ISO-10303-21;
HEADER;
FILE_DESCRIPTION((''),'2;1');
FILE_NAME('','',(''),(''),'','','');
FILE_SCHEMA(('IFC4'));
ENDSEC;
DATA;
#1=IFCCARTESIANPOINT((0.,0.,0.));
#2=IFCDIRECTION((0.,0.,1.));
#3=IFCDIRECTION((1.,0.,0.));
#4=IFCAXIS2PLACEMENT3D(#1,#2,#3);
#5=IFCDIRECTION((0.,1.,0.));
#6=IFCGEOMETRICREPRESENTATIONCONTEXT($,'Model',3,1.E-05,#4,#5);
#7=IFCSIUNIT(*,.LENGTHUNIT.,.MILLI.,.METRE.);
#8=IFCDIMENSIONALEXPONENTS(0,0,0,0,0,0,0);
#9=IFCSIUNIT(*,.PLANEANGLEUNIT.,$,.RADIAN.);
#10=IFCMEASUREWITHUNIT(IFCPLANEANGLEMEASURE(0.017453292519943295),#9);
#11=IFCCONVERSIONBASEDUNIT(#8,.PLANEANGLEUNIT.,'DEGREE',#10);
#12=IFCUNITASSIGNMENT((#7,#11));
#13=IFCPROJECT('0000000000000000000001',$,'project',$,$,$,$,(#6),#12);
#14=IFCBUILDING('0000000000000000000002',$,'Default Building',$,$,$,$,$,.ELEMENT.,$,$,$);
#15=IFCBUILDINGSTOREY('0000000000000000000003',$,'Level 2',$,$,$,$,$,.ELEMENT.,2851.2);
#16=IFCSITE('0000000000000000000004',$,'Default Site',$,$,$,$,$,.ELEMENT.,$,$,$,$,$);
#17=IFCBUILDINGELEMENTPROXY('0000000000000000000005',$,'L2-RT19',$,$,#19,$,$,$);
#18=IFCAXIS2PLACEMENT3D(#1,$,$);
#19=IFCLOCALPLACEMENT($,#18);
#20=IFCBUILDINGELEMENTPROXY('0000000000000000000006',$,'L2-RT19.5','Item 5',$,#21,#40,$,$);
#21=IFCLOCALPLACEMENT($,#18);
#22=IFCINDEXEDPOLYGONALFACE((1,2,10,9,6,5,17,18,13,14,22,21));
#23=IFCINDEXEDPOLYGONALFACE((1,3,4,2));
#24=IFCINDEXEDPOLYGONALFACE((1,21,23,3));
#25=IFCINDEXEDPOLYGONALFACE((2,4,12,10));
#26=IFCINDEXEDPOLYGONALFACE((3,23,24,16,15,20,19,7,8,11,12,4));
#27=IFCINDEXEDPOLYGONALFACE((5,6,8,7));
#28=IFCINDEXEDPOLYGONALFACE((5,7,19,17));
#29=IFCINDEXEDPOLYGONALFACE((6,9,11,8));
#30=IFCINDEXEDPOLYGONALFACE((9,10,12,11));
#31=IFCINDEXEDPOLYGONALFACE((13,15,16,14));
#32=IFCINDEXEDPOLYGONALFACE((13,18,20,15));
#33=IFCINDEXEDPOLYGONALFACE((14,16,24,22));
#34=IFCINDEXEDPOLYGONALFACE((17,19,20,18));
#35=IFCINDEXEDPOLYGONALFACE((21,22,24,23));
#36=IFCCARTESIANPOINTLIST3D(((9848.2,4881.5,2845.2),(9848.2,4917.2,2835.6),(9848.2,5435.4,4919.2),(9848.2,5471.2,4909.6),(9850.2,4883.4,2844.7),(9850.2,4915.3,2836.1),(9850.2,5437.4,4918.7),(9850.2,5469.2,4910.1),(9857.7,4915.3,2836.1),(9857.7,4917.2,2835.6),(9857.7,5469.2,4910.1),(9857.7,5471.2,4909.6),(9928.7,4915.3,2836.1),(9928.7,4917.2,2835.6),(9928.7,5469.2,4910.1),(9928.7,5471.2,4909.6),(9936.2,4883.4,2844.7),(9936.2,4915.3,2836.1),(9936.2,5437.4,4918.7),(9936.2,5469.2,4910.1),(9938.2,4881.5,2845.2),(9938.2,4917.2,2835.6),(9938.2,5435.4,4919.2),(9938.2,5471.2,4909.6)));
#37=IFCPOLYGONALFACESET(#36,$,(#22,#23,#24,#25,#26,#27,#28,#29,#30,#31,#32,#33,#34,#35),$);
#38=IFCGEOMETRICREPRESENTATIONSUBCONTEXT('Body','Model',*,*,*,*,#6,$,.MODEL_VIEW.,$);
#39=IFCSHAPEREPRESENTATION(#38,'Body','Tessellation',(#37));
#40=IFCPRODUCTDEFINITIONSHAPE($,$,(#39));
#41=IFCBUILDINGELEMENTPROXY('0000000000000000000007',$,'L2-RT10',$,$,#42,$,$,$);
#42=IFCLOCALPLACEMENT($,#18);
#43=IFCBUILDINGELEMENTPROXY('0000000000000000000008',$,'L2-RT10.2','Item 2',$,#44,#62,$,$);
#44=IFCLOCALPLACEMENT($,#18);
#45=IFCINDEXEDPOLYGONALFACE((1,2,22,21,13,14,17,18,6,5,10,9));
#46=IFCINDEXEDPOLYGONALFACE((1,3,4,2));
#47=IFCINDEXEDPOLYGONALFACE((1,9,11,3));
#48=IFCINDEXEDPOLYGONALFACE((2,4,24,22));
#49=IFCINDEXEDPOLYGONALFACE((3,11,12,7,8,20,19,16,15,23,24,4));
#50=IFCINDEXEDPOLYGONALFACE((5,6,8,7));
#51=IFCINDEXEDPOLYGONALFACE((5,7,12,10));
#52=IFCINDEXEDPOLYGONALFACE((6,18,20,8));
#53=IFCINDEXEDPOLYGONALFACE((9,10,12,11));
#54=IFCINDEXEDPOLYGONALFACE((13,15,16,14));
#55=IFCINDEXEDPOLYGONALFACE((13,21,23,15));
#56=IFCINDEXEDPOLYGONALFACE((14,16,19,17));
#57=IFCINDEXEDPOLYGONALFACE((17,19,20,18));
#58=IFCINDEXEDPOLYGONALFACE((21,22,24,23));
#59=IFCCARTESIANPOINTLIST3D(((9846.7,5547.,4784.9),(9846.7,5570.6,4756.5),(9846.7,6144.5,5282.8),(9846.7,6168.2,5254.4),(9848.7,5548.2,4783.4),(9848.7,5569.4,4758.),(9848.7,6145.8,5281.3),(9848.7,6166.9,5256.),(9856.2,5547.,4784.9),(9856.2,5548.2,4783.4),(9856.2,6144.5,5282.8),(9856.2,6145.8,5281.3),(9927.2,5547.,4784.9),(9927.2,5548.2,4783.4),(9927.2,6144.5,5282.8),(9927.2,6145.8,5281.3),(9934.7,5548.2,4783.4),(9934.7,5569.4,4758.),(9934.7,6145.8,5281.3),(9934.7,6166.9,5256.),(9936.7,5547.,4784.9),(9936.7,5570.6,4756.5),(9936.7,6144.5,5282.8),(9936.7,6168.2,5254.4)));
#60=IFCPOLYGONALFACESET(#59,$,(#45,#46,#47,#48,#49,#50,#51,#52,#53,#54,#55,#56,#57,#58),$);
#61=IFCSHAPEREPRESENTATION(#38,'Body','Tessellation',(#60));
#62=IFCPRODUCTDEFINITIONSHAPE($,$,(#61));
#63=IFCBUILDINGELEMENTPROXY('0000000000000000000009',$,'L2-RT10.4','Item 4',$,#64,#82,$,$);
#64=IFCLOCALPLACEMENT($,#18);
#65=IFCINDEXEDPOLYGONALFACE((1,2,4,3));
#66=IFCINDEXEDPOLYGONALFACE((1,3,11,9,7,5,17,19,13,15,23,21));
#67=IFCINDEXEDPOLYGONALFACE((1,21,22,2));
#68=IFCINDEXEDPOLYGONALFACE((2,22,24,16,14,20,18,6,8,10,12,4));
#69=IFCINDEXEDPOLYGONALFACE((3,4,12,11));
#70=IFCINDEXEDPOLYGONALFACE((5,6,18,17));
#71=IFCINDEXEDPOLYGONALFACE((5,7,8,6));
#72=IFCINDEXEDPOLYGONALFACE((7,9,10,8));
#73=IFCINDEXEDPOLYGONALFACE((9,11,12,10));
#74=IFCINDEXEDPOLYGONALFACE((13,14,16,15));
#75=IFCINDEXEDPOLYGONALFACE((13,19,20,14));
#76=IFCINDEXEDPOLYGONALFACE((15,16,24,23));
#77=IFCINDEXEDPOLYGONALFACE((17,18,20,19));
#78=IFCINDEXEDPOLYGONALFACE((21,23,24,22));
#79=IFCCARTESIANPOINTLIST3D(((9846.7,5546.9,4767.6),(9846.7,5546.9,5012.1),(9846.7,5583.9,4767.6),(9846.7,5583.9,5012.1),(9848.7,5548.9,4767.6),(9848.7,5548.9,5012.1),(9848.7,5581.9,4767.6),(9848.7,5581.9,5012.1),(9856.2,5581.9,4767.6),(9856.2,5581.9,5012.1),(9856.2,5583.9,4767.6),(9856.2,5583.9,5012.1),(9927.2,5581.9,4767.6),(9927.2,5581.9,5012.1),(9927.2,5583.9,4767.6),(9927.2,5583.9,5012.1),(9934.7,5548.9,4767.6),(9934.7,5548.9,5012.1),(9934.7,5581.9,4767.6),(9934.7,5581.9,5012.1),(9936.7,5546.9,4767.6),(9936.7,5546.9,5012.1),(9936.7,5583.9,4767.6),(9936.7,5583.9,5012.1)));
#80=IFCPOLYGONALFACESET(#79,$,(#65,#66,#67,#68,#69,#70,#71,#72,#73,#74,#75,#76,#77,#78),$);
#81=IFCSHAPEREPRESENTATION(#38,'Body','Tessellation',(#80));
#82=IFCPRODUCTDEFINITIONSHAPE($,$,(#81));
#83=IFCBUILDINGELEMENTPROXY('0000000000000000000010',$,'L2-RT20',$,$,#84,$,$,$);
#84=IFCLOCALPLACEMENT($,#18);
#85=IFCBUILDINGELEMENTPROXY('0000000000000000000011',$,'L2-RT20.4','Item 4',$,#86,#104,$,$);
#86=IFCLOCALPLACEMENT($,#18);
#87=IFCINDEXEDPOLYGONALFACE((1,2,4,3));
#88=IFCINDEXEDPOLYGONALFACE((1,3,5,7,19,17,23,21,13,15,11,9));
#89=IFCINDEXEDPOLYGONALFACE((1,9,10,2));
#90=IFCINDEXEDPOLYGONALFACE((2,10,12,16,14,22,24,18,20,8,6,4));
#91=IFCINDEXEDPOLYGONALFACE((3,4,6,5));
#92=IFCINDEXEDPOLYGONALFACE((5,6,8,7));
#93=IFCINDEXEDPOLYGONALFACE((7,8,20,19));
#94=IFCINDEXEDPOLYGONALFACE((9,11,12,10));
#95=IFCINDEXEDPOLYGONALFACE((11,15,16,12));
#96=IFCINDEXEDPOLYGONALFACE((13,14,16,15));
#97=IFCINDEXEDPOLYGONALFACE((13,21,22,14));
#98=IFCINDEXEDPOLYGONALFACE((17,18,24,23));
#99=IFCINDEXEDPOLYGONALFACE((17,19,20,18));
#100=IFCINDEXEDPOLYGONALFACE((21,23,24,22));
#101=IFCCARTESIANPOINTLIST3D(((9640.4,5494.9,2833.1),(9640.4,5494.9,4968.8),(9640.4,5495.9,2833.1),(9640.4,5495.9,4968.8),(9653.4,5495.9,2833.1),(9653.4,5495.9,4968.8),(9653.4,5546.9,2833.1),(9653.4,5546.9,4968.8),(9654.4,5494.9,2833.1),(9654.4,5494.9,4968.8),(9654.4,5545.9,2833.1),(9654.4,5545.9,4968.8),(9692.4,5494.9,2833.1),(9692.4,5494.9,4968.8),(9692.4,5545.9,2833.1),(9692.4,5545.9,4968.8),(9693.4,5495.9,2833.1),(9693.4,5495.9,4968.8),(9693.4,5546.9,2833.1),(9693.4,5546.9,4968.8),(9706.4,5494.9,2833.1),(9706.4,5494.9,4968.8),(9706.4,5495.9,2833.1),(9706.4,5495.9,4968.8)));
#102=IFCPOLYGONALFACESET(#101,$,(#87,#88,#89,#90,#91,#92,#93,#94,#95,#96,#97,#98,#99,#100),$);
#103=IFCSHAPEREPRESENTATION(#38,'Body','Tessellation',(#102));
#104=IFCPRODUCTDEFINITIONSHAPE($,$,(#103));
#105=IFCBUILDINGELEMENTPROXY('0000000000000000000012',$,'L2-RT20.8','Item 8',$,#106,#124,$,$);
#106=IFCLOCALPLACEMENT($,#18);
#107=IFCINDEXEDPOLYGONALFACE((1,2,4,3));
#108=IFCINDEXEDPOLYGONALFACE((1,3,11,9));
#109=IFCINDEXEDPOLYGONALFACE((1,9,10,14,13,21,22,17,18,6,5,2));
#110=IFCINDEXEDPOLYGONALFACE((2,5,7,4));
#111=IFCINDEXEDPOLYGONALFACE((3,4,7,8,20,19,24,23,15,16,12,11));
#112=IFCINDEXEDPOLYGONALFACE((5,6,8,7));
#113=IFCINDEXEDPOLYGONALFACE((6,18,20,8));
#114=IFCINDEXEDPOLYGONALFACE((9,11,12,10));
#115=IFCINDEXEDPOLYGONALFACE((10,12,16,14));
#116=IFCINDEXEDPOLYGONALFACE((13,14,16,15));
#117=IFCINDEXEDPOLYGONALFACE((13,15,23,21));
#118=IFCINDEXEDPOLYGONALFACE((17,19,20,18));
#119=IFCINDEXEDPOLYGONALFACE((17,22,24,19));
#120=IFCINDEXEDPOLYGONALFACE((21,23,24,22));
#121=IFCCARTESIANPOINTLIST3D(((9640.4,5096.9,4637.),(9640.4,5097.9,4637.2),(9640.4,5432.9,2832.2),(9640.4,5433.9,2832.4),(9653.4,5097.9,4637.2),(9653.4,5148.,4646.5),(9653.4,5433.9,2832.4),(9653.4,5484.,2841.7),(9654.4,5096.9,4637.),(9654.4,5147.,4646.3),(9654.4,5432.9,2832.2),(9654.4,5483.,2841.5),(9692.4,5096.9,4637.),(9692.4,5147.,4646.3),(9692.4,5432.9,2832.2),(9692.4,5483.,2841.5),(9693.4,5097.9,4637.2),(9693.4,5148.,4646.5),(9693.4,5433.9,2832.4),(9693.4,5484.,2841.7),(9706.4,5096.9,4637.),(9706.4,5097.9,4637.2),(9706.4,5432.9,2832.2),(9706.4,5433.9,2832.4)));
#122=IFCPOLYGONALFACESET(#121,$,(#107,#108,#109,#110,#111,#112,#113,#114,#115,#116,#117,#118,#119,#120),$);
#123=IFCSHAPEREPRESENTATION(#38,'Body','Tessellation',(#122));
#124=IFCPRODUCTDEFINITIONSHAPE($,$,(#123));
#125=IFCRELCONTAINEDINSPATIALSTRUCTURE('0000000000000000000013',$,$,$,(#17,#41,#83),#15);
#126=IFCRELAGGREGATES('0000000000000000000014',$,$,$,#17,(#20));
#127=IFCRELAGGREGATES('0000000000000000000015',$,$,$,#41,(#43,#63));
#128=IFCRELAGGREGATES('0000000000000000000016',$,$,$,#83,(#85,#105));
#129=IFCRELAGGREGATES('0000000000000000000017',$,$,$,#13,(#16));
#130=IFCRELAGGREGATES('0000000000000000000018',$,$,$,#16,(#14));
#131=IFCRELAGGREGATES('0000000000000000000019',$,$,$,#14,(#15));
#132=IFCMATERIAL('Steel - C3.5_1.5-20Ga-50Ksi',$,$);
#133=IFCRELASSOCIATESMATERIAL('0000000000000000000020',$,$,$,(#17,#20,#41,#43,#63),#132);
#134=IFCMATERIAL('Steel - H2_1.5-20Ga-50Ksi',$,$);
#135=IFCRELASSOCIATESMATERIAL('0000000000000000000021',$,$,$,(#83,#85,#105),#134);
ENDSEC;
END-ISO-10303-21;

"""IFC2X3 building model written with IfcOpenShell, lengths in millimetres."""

from ifc_helpers import new_model, entity, si_unit, converted_unit, direction, frame, origin, origin_with_axes, origin_2d_with_axis, place, context, subcontext, project, spatial, polyline, c_section, outline, extrude, material, element, aggregate, save


model = new_model("IFC2X3")

# Units and contexts
model_context = context("Model", 3, precision=1e-05, world=origin_with_axes(), true_north=direction((0.0, 1.0, 0.0)))
body_context = subcontext(model_context, "Body", "Model", "MODEL_VIEW")
ifc_project = project(units=[si_unit("LENGTHUNIT", "METRE", prefix="MILLI"), converted_unit("PLANEANGLEUNIT", "DEGREE", entity("IfcPlaneAngleMeasure", 0.017453292519943295), si_unit("PLANEANGLEUNIT", "RADIAN"), dimensions=[0, 0, 0, 0, 0, 0, 0])], contexts=[model_context])

# Site, building, storey
site = spatial("IfcSite", under=ifc_project, Name="Default Site", CompositionType="ELEMENT")
building = spatial("IfcBuilding", under=site, Name="Default Building", CompositionType="ELEMENT")
storey = spatial("IfcBuildingStorey", under=building, Name="Level 2", CompositionType="ELEMENT", Elevation=2851.2)

# Shared definitions
ifc_material_1 = material(Name="Steel - C3.5_1.5-20Ga-50Ksi")

# Building element proxies
ifc_material_2 = material(Name="Steel - H2_1.5-20Ga-50Ksi")
proxy_1 = element("IfcBuildingElementProxy", 1, inside=storey, material=ifc_material_1, Name="L2-RT19")
proxy_2_placement = place(None, frame((9893.2, 5453.3, 4914.4), z_axis=(0.0, -0.258, -0.966), x_axis=(0.0, 35.747, -9.548)))
proxy_2 = element("IfcBuildingElementProxy", 2, at=proxy_2_placement, material=ifc_material_1, Name="L2-RT19.5", Description="Item 5", context=body_context, shape_type="SweptSolid", body=[
    extrude(c_section(Depth=90.0, Width=37.0, WallThickness=2.0, Girth=9.5, at=origin_2d_with_axis()), origin(), (0.0, 0.0, 1.0), 2146.7),
])
aggregate(proxy_1, [proxy_2])
proxy_3 = element("IfcBuildingElementProxy", 3, inside=storey, material=ifc_material_1, Name="L2-RT10")
proxy_4_placement = place(None, frame((9891.7, 5558.8, 4770.7), z_axis=(0.0, 0.768, 0.64), x_axis=(0.0, -23.689, 28.422)))
proxy_4 = element("IfcBuildingElementProxy", 4, at=proxy_4_placement, material=ifc_material_1, Name="L2-RT10.2", Description="Item 2", context=body_context, shape_type="SweptSolid", body=[
    extrude(c_section(Depth=90.0, Width=37.0, WallThickness=2.0, Girth=9.5, at=origin_2d_with_axis()), origin(), (0.0, 0.0, 1.0), 777.8),
])
proxy_5_placement = place(None, frame((9891.7, 5565.4, 5012.1), z_axis=(0.0, 0.0, -1.0), x_axis=(0.0, 37.0, 0.0)))
proxy_5 = element("IfcBuildingElementProxy", 5, at=proxy_5_placement, material=ifc_material_1, Name="L2-RT10.4", Description="Item 4", context=body_context, shape_type="SweptSolid", body=[
    extrude(c_section(Depth=90.0, Width=37.0, WallThickness=2.0, Girth=9.5, at=origin_2d_with_axis()), origin(), (0.0, 0.0, 1.0), 244.5),
])
aggregate(proxy_3, [proxy_4, proxy_5])
proxy_6 = element("IfcBuildingElementProxy", 6, inside=storey, material=ifc_material_2, Name="L2-RT20")
proxy_7_placement = place(None, frame((9706.4, 5494.9, 4968.8), z_axis=(0.0, 0.0, -1.0), x_axis=(-40.0, 0.0, 0.0)))
proxy_7 = element("IfcBuildingElementProxy", 7, at=proxy_7_placement, material=ifc_material_2, Name="L2-RT20.4", Description="Item 4", context=body_context, shape_type="SweptSolid", body=[
    extrude(outline(polyline([(0.0, 0.0), (14.0, 0.0), (14.0, 51.0), (52.0, 51.0), (52.0, 0.0), (66.0, 0.0), (66.0, 1.0), (53.0, 1.0), (53.0, 52.0), (13.0, 52.0), (13.0, 1.0), (0.0, 1.0), (0.0, 0.0)])), origin(), (0.0, 0.0, 1.0), 2135.7),
])
proxy_8_placement = place(None, frame((9706.4, 5096.9, 4637.0), z_axis=(0.0, 0.183, -0.983), x_axis=(-40.0, 0.0, 0.0)))
proxy_8 = element("IfcBuildingElementProxy", 8, at=proxy_8_placement, material=ifc_material_2, Name="L2-RT20.8", Description="Item 8", context=body_context, shape_type="SweptSolid", body=[
    extrude(outline(polyline([(0.0, 0.0), (14.0, 0.0), (14.0, 51.0), (52.0, 51.0), (52.0, 0.0), (66.0, 0.0), (66.0, 1.0), (53.0, 1.0), (53.0, 52.0), (13.0, 52.0), (13.0, 1.0), (0.0, 1.0), (0.0, 0.0)])), origin(), (0.0, 0.0, 1.0), 1835.8),
])
aggregate(proxy_6, [proxy_7, proxy_8])

save(model, "model.ifc")
